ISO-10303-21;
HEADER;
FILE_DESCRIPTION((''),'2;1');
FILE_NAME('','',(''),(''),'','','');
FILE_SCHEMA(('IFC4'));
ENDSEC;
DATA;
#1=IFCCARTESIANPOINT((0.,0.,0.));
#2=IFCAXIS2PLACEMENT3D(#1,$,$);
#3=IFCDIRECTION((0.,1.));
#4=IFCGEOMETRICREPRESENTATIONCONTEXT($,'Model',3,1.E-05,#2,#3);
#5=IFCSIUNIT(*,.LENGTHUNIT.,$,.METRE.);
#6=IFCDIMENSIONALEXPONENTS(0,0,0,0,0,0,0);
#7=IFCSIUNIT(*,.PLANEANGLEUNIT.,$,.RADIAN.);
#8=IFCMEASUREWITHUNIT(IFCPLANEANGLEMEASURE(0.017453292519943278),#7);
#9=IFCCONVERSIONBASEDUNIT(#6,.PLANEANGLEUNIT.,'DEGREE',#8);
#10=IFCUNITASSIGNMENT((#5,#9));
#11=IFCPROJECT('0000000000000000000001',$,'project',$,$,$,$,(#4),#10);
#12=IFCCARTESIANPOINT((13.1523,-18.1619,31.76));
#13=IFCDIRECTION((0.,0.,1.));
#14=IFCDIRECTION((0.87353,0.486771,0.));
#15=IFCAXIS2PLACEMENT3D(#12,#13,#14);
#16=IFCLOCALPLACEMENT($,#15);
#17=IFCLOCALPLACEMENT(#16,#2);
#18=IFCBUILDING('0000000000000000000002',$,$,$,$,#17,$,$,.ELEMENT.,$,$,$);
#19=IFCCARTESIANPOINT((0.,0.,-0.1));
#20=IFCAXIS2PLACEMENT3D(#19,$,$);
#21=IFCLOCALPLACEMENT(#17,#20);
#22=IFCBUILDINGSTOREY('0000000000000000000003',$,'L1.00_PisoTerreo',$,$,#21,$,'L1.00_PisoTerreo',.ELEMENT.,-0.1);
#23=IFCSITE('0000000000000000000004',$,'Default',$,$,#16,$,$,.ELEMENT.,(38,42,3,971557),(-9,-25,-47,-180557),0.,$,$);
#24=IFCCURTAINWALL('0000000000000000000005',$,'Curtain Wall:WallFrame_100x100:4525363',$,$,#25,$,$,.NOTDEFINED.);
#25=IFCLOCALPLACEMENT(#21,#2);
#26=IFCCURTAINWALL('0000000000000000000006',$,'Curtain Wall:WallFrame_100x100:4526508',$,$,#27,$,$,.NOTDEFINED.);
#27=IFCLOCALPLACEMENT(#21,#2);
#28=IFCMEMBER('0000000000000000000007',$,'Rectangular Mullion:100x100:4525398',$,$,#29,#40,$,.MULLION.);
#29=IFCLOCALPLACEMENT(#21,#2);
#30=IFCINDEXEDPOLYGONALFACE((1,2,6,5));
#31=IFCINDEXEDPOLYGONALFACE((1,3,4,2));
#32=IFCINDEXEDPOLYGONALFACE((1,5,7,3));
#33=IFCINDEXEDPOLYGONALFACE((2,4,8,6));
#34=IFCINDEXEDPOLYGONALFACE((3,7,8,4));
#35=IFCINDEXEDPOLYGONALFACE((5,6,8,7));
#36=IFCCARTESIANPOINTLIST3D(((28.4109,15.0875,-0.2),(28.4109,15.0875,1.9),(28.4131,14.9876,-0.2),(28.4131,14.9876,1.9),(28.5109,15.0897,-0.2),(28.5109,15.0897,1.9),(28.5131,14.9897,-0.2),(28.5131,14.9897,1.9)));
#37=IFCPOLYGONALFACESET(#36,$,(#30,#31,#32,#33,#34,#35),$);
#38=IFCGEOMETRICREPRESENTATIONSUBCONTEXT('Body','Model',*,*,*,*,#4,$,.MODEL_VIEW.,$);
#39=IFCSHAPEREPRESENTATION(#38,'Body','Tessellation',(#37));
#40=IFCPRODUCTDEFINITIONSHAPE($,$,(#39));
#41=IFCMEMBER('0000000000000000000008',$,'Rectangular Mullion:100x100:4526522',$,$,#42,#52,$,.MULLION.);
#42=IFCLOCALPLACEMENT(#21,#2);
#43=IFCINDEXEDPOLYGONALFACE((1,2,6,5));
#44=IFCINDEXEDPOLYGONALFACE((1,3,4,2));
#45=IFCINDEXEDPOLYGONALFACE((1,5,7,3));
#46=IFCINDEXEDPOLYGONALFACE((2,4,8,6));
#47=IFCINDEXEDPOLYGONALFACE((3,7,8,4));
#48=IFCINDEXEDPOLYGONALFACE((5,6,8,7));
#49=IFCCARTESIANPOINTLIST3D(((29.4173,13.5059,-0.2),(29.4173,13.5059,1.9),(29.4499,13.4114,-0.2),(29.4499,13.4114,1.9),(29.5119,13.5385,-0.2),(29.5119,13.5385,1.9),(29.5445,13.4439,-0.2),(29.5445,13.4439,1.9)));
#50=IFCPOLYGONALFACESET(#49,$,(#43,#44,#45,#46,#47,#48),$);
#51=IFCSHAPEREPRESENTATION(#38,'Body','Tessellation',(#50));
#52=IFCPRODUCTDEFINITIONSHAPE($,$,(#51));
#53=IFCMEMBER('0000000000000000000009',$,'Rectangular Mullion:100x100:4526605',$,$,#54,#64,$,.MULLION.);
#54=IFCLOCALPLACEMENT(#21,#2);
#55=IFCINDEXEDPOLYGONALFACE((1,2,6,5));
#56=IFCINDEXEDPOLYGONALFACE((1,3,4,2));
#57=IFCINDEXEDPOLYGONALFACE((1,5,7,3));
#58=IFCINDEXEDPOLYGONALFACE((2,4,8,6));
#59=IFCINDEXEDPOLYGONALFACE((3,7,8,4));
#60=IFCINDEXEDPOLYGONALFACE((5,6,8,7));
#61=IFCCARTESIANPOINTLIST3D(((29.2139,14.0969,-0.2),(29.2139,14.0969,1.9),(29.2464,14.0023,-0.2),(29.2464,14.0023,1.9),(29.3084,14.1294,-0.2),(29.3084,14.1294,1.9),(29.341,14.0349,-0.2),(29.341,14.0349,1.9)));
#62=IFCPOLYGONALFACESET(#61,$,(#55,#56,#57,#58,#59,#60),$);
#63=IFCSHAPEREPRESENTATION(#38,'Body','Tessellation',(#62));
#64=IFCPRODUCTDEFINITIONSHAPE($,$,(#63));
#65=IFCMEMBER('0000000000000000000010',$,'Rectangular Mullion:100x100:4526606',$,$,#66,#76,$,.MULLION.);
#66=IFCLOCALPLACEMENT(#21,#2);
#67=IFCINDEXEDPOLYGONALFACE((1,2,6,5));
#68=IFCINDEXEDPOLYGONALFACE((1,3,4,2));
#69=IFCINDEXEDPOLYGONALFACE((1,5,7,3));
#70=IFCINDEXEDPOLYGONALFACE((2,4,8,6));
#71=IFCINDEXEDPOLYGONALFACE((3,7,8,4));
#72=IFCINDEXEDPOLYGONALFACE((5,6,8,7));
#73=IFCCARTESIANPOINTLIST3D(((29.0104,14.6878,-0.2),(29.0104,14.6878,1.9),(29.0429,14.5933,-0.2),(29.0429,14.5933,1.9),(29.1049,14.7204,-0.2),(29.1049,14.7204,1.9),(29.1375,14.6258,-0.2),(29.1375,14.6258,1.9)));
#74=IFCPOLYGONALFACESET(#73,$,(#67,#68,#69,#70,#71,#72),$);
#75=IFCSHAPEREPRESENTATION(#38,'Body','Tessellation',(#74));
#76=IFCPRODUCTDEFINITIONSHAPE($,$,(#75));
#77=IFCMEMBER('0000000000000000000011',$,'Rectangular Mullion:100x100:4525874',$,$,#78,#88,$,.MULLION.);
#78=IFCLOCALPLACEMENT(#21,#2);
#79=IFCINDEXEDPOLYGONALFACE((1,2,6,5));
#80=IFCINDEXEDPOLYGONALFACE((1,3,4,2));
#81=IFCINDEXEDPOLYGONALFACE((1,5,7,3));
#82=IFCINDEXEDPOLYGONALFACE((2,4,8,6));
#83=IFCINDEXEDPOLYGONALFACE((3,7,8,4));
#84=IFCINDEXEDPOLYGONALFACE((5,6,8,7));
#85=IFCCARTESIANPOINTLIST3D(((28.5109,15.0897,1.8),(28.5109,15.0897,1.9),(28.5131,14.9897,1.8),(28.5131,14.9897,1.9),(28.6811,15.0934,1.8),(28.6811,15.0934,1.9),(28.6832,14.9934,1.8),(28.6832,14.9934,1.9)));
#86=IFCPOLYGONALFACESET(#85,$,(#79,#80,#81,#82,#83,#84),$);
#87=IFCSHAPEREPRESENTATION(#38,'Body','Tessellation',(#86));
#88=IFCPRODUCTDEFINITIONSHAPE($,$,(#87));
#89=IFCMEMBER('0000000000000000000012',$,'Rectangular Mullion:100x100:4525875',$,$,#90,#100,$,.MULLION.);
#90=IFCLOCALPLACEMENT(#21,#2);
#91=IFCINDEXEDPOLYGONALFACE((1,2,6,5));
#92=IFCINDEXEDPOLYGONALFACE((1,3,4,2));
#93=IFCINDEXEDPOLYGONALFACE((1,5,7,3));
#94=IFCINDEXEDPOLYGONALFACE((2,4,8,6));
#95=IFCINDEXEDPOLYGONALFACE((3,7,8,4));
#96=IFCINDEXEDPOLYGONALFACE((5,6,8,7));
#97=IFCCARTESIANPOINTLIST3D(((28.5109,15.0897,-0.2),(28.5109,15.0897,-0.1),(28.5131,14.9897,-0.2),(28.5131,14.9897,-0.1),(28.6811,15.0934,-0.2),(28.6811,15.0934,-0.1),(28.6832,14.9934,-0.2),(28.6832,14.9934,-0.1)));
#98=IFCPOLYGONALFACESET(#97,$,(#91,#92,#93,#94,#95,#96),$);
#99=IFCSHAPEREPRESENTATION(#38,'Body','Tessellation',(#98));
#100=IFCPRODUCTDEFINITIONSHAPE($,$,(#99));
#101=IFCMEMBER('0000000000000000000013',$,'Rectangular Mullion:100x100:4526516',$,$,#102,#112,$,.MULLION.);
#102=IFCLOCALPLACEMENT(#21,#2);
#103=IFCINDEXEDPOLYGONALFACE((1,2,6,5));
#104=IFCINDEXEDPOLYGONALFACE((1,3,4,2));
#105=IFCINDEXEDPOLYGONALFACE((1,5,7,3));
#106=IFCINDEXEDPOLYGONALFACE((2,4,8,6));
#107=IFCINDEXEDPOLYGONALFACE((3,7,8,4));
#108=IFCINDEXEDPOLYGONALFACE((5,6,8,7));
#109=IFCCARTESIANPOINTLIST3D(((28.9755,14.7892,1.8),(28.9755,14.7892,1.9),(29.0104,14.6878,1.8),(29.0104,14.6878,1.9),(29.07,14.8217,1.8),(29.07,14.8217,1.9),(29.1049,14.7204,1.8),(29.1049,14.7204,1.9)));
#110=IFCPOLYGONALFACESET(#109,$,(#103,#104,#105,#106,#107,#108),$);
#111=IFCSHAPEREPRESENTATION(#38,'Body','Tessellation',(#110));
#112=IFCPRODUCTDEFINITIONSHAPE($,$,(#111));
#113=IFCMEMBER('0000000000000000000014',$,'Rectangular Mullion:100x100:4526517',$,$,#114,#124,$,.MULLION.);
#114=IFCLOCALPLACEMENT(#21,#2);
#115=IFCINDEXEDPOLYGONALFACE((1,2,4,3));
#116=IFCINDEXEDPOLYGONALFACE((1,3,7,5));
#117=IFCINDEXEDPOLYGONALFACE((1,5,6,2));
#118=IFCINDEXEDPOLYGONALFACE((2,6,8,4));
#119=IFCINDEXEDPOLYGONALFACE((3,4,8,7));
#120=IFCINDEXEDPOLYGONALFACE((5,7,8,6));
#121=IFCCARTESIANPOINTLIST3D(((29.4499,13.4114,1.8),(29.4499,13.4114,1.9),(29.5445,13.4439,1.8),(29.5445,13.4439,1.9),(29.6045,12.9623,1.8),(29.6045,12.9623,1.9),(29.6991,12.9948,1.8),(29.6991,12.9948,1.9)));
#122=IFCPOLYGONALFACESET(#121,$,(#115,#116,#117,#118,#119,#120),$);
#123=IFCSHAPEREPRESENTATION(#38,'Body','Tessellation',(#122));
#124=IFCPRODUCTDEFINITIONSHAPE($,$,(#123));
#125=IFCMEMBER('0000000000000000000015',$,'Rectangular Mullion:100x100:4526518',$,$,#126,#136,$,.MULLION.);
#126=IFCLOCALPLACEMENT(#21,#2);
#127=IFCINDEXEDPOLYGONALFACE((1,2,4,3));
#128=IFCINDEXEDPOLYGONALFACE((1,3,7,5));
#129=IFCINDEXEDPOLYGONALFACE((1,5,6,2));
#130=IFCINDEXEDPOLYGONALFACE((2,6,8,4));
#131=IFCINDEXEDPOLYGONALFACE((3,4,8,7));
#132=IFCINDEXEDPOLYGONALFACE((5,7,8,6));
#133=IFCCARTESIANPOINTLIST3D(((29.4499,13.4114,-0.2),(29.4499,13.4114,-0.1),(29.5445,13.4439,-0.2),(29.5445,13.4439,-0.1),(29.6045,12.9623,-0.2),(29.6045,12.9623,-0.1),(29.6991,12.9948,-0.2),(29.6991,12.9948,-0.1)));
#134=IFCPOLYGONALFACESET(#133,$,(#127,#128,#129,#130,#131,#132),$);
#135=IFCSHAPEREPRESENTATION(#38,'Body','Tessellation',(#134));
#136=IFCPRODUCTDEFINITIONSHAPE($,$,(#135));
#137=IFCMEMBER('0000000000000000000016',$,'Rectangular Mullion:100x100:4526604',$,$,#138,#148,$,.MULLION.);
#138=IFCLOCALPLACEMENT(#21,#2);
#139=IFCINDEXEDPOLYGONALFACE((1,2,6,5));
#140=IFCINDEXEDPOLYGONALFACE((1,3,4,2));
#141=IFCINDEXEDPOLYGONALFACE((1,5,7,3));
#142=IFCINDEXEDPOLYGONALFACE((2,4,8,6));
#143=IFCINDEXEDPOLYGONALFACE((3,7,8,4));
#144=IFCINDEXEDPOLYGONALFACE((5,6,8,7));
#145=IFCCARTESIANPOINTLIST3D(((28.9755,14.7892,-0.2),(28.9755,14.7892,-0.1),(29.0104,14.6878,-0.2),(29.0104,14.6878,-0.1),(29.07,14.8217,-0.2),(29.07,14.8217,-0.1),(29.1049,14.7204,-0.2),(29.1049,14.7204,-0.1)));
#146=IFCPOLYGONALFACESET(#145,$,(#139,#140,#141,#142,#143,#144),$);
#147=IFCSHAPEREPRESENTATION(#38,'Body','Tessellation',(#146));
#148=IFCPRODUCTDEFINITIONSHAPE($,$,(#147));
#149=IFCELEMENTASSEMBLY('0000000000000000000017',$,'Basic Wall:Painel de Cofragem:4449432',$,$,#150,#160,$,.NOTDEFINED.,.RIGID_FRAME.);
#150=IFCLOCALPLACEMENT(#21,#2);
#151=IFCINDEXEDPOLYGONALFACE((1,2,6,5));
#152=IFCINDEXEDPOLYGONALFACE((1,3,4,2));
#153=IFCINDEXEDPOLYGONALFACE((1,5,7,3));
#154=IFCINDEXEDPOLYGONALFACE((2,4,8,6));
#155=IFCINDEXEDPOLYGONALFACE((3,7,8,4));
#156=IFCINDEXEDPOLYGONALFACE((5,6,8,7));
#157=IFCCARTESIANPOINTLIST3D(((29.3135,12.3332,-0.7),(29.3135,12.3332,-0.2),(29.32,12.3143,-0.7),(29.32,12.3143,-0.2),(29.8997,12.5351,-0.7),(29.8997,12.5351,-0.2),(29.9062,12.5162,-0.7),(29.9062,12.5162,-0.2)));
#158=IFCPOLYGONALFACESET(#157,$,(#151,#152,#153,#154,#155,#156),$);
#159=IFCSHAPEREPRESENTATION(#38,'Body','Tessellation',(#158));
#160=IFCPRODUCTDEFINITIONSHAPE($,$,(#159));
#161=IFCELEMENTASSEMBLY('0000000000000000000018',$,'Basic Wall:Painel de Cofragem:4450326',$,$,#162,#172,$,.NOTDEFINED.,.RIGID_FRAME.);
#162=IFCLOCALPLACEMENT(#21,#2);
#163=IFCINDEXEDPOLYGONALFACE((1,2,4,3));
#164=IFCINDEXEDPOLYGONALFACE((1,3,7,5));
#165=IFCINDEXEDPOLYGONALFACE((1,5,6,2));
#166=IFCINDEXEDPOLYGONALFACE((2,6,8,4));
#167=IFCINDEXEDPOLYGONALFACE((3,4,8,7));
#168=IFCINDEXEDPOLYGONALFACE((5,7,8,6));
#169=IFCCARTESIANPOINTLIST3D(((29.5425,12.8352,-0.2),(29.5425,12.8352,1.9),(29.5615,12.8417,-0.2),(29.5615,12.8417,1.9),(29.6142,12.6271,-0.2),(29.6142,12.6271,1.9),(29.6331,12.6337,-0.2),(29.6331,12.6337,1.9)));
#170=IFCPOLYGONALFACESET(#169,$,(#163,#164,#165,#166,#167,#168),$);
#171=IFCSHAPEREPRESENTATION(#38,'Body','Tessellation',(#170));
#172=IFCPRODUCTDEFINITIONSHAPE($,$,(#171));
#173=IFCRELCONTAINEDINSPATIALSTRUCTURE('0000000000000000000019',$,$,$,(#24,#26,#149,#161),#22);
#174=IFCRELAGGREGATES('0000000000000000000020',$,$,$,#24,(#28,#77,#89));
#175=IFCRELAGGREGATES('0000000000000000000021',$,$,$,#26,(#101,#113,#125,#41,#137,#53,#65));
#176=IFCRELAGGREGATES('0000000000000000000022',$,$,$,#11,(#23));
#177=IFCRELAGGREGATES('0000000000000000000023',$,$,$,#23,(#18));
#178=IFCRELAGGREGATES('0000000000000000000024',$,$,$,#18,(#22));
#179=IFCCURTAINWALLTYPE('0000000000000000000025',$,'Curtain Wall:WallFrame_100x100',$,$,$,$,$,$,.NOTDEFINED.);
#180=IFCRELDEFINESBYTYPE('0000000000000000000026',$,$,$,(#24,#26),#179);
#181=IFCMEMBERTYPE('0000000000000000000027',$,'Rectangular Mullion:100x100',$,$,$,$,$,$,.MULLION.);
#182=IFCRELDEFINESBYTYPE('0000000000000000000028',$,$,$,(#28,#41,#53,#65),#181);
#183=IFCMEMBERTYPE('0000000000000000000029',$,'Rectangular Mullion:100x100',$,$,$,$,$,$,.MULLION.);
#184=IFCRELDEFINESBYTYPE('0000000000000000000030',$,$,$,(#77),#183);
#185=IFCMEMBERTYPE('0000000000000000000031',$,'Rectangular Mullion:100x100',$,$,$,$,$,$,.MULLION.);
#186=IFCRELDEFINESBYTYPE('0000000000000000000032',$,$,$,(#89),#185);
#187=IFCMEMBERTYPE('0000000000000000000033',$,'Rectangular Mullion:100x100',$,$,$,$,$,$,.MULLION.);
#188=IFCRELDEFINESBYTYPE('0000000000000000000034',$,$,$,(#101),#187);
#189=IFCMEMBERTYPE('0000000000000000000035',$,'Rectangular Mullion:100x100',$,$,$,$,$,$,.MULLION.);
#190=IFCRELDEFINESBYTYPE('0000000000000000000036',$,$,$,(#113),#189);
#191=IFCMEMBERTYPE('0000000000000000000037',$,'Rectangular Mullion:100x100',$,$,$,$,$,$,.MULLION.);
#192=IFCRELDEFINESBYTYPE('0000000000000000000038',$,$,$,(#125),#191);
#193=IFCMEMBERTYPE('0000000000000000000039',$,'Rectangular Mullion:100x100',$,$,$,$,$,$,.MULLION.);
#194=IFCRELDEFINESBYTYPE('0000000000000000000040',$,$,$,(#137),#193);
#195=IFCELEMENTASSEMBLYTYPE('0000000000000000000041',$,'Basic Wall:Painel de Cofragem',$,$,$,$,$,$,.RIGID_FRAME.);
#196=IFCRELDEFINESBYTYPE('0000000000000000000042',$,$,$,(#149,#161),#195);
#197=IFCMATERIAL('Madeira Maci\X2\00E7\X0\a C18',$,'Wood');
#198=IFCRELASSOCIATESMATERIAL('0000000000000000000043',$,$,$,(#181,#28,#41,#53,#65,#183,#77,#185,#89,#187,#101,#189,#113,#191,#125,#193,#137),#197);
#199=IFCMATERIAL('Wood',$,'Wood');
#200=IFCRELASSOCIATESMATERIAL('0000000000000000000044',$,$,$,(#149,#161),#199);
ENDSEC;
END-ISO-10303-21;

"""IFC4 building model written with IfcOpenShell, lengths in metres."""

from ifc_helpers import new_model, entity, si_unit, converted_unit, direction, frame, origin, place, context, subcontext, project, spatial, indexed_curve, outline, extrude, source, transform, mapped, material, type_object, type_shapes, element, aggregate, save


model = new_model("IFC4")

# Units and contexts
model_context = context("Model", 3, precision=1e-05, world=origin(), true_north=direction((0.0, 1.0)))
body_context = subcontext(model_context, "Body", "Model", "MODEL_VIEW")
ifc_project = project(units=[si_unit("LENGTHUNIT", "METRE"), converted_unit("PLANEANGLEUNIT", "DEGREE", entity("IfcPlaneAngleMeasure", 0.017453292519943278), si_unit("PLANEANGLEUNIT", "RADIAN"), dimensions=[0, 0, 0, 0, 0, 0, 0])], contexts=[model_context])

# Site, building, storey
site_placement = place(None, frame((13.1523, -18.1619, 31.76), z_axis=(0.0, 0.0, 1.0), x_axis=(0.87353, 0.486771, 0.0)))
site = spatial("IfcSite", under=ifc_project, at=site_placement, Name="Default", CompositionType="ELEMENT", RefLatitude=(38, 42, 3, 971557), RefLongitude=(-9, -25, -47, -180557), RefElevation=0.0)
building_placement = place(site_placement, origin())
building = spatial("IfcBuilding", under=site, at=building_placement, CompositionType="ELEMENT")
storey_placement = place(building_placement, frame((0.0, 0.0, -0.1)))
storey = spatial("IfcBuildingStorey", under=building, at=storey_placement, Name="L1.00_PisoTerreo", LongName="L1.00_PisoTerreo", CompositionType="ELEMENT", Elevation=-0.1)

# Curtain walls
curtain_wall_type = type_object("IfcCurtainWallType", Name="Curtain Wall:WallFrame_100x100", PredefinedType="NOTDEFINED")
curtain_wall_1_placement = place(storey_placement, frame((0.0, 0.0, 0.1)))
curtain_wall_1 = element("IfcCurtainWall", 1, at=curtain_wall_1_placement, inside=storey, type_object=curtain_wall_type, Name="Curtain Wall:WallFrame_100x100:4525363", PredefinedType="NOTDEFINED")
ifc_material_1 = material(Name="Madeira Maciça C18", Category="Wood")
curtain_wall_2_placement = place(storey_placement, frame((0.0, 0.0, 0.1)))
curtain_wall_2 = element("IfcCurtainWall", 2, at=curtain_wall_2_placement, inside=storey, type_object=curtain_wall_type, Name="Curtain Wall:WallFrame_100x100:4526508", PredefinedType="NOTDEFINED")

# Members
member_type_1 = type_object("IfcMemberType", Name="Rectangular Mullion:100x100", PredefinedType="MULLION", material=ifc_material_1)
shared_shape_1 = source(origin(), body_context, "Body", "SweptSolid", [
    extrude(outline(indexed_curve([(-0.05, -0.05), (0.05, -0.05), (0.05, 0.05), (-0.05, 0.05), (-0.05, -0.05)], self_intersect=False)), frame((0.0, 0.0, -2.1), z_axis=(0.0, 0.0, 1.0), x_axis=(-1.0, 0.0, 0.0)), (0.0, 0.0, 1.0), 2.1),
])
type_shapes(member_type_1, [shared_shape_1])
member_1_placement = place(curtain_wall_1_placement, frame((28.462, 15.0386, -0.3), z_axis=(0.0, 0.0, -1.0), x_axis=(0.999767, 0.021581, 0.0)))
member_1 = element("IfcMember", 3, at=member_1_placement, type_object=member_type_1, material=ifc_material_1, Name="Rectangular Mullion:100x100:4525398", PredefinedType="MULLION", context=body_context, shape_type="MappedRepresentation", body=[
    mapped(shared_shape_1, transform((0.0, 0.0, 0.0), scale=1.0)),
])
member_2_placement = place(curtain_wall_2_placement, frame((29.4809, 13.4749, -0.3), z_axis=(0.0, 0.0, -1.0), x_axis=(-0.325568, 0.945519, 0.0)))
member_2 = element("IfcMember", 4, at=member_2_placement, type_object=member_type_1, material=ifc_material_1, Name="Rectangular Mullion:100x100:4526522", PredefinedType="MULLION", context=body_context, shape_type="MappedRepresentation", body=[
    mapped(shared_shape_1, transform((0.0, 0.0, 0.0), scale=1.0)),
])
member_3_placement = place(curtain_wall_2_placement, frame((29.2774, 14.0659, -0.3), z_axis=(0.0, 0.0, -1.0), x_axis=(-0.325568, 0.945519, 0.0)))
member_3 = element("IfcMember", 5, at=member_3_placement, type_object=member_type_1, material=ifc_material_1, Name="Rectangular Mullion:100x100:4526605", PredefinedType="MULLION", context=body_context, shape_type="MappedRepresentation", body=[
    mapped(shared_shape_1, transform((0.0, 0.0, 0.0), scale=1.0)),
])
member_4_placement = place(curtain_wall_2_placement, frame((29.0739, 14.6568, -0.3), z_axis=(0.0, 0.0, -1.0), x_axis=(-0.325568, 0.945519, 0.0)))
member_4 = element("IfcMember", 6, at=member_4_placement, type_object=member_type_1, material=ifc_material_1, Name="Rectangular Mullion:100x100:4526606", PredefinedType="MULLION", context=body_context, shape_type="MappedRepresentation", body=[
    mapped(shared_shape_1, transform((0.0, 0.0, 0.0), scale=1.0)),
])
member_type_2 = type_object("IfcMemberType", Name="Rectangular Mullion:100x100", PredefinedType="MULLION", material=ifc_material_1)
shared_shape_2 = source(origin(), body_context, "Body", "SweptSolid", [
    extrude(outline(indexed_curve([(-0.05, -0.05), (0.05, -0.05), (0.05, 0.05), (-0.05, 0.05), (-0.05, -0.05)], self_intersect=False)), frame((-0.05, 0.0, -0.1702), z_axis=(0.0, 0.0, 1.0), x_axis=(-1.0, 0.0, 0.0)), (0.0, 0.0, 1.0), 0.1702),
])
type_shapes(member_type_2, [shared_shape_2])
member_5_placement = place(curtain_wall_1_placement, frame((28.6821, 15.0434, 1.8), z_axis=(0.999767, 0.021581, 0.0), x_axis=(0.0, 0.0, 1.0)))
member_5 = element("IfcMember", 7, at=member_5_placement, type_object=member_type_2, material=ifc_material_1, Name="Rectangular Mullion:100x100:4525874", PredefinedType="MULLION", context=body_context, shape_type="MappedRepresentation", body=[
    mapped(shared_shape_2, transform((0.0, 0.0, 0.0), scale=1.0)),
])
member_type_3 = type_object("IfcMemberType", Name="Rectangular Mullion:100x100", PredefinedType="MULLION", material=ifc_material_1)
shared_shape_3 = source(origin(), body_context, "Body", "SweptSolid", [
    extrude(outline(indexed_curve([(-0.05, -0.05), (0.05, -0.05), (0.05, 0.05), (-0.05, 0.05), (-0.05, -0.05)], self_intersect=False)), frame((-0.05, 0.0, -0.1702), z_axis=(0.0, 0.0, 1.0), x_axis=(0.0, -1.0, 0.0)), (0.0, 0.0, 1.0), 0.1702),
])
type_shapes(member_type_3, [shared_shape_3])
member_6_placement = place(curtain_wall_1_placement, frame((28.512, 15.0397, -0.3), z_axis=(-0.999767, -0.021581, 0.0), x_axis=(0.0, 0.0, -1.0)))
member_6 = element("IfcMember", 8, at=member_6_placement, type_object=member_type_3, material=ifc_material_1, Name="Rectangular Mullion:100x100:4525875", PredefinedType="MULLION", context=body_context, shape_type="MappedRepresentation", body=[
    mapped(shared_shape_3, transform((0.0, 0.0, 0.0), scale=1.0)),
])
aggregate(curtain_wall_1, [member_1, member_5, member_6])
member_type_4 = type_object("IfcMemberType", Name="Rectangular Mullion:100x100", PredefinedType="MULLION", material=ifc_material_1)
shared_shape_4 = source(origin(), body_context, "Body", "SweptSolid", [
    extrude(outline(indexed_curve([(-0.05, -0.05), (0.05, -0.05), (0.05, 0.05), (-0.05, 0.05), (-0.05, -0.05)], self_intersect=False)), frame((-0.05, 0.0, -0.1072), z_axis=(0.0, 0.0, 1.0), x_axis=(-1.0, 0.0, 0.0)), (0.0, 0.0, 1.0), 0.1072),
])
type_shapes(member_type_4, [shared_shape_4])
member_7_placement = place(curtain_wall_2_placement, frame((29.0228, 14.8054, 1.8), z_axis=(-0.325568, 0.945519, 0.0), x_axis=(0.0, 0.0, 1.0)))
member_7 = element("IfcMember", 9, at=member_7_placement, type_object=member_type_4, material=ifc_material_1, Name="Rectangular Mullion:100x100:4526516", PredefinedType="MULLION", context=body_context, shape_type="MappedRepresentation", body=[
    mapped(shared_shape_4, transform((0.0, 0.0, 0.0), scale=1.0)),
])
member_type_5 = type_object("IfcMemberType", Name="Rectangular Mullion:100x100", PredefinedType="MULLION", material=ifc_material_1)
shared_shape_5 = source(origin(), body_context, "Body", "SweptSolid", [
    extrude(outline(indexed_curve([(-0.05, -0.05), (0.05, -0.05), (0.05, 0.05), (-0.05, 0.05), (-0.05, -0.05)], self_intersect=False)), frame((-0.05, 0.0, -0.475), z_axis=(0.0, 0.0, 1.0), x_axis=(-1.0, 0.0, 0.0)), (0.0, 0.0, 1.0), 0.475),
])
type_shapes(member_type_5, [shared_shape_5])
member_8_placement = place(curtain_wall_2_placement, frame((29.4972, 13.4277, 1.8), z_axis=(-0.325568, 0.945519, 0.0), x_axis=(0.0, 0.0, 1.0)))
member_8 = element("IfcMember", 10, at=member_8_placement, type_object=member_type_5, material=ifc_material_1, Name="Rectangular Mullion:100x100:4526517", PredefinedType="MULLION", context=body_context, shape_type="MappedRepresentation", body=[
    mapped(shared_shape_5, transform((0.0, 0.0, 0.0), scale=1.0)),
])
member_type_6 = type_object("IfcMemberType", Name="Rectangular Mullion:100x100", PredefinedType="MULLION", material=ifc_material_1)
shared_shape_6 = source(origin(), body_context, "Body", "SweptSolid", [
    extrude(outline(indexed_curve([(-0.05, -0.05), (0.05, -0.05), (0.05, 0.05), (-0.05, 0.05), (-0.05, -0.05)], self_intersect=False)), frame((-0.05, 0.0, -0.475), z_axis=(0.0, 0.0, 1.0), x_axis=(0.0, -1.0, 0.0)), (0.0, 0.0, 1.0), 0.475),
])
type_shapes(member_type_6, [shared_shape_6])
member_9_placement = place(curtain_wall_2_placement, frame((29.6518, 12.9785, -0.3), z_axis=(0.325568, -0.945519, 0.0), x_axis=(0.0, 0.0, -1.0)))
member_9 = element("IfcMember", 11, at=member_9_placement, type_object=member_type_6, material=ifc_material_1, Name="Rectangular Mullion:100x100:4526518", PredefinedType="MULLION", context=body_context, shape_type="MappedRepresentation", body=[
    mapped(shared_shape_6, transform((0.0, 0.0, 0.0), scale=1.0)),
])
member_type_7 = type_object("IfcMemberType", Name="Rectangular Mullion:100x100", PredefinedType="MULLION", material=ifc_material_1)
shared_shape_7 = source(origin(), body_context, "Body", "SweptSolid", [
    extrude(outline(indexed_curve([(-0.05, -0.05), (0.05, -0.05), (0.05, 0.05), (-0.05, 0.05), (-0.05, -0.05)], self_intersect=False)), frame((-0.05, 0.0, -0.1072), z_axis=(0.0, 0.0, 1.0), x_axis=(0.0, -1.0, 0.0)), (0.0, 0.0, 1.0), 0.1072),
])
type_shapes(member_type_7, [shared_shape_7])
member_10_placement = place(curtain_wall_2_placement, frame((29.0577, 14.7041, -0.3), z_axis=(0.325568, -0.945519, 0.0), x_axis=(0.0, 0.0, -1.0)))
member_10 = element("IfcMember", 12, at=member_10_placement, type_object=member_type_7, material=ifc_material_1, Name="Rectangular Mullion:100x100:4526604", PredefinedType="MULLION", context=body_context, shape_type="MappedRepresentation", body=[
    mapped(shared_shape_7, transform((0.0, 0.0, 0.0), scale=1.0)),
])
aggregate(curtain_wall_2, [member_7, member_8, member_9, member_2, member_10, member_3, member_4])

# Element assemblies
ifc_material_2 = material(Name="Wood", Category="Wood")
element_assembly_type = type_object("IfcElementAssemblyType", Name="Basic Wall:Painel de Cofragem", PredefinedType="RIGID_FRAME")
assembly_1_placement = place(storey_placement, frame((29.3167, 12.3238, -0.7), z_axis=(0.0, 0.0, 1.0), x_axis=(0.945519, 0.325568, 0.0)))
element("IfcElementAssembly", 13, at=assembly_1_placement, inside=storey, type_object=element_assembly_type, material=ifc_material_2, Name="Basic Wall:Painel de Cofragem:4449432", AssemblyPlace="NOTDEFINED", PredefinedType="RIGID_FRAME", context=body_context, shape_type="SweptSolid", body=[
    extrude(outline(indexed_curve([(0.62, 0.01), (0.0, 0.01), (0.0, -0.01), (0.62, -0.01), (0.62, 0.01)], self_intersect=False)), origin(), (0.0, 0.0, 1.0), 0.5),
])
assembly_2_placement = place(storey_placement, frame((29.552, 12.8384, -0.2), z_axis=(0.0, 0.0, 1.0), x_axis=(0.325568, -0.945519, 0.0)))
element("IfcElementAssembly", 14, at=assembly_2_placement, inside=storey, type_object=element_assembly_type, material=ifc_material_2, Name="Basic Wall:Painel de Cofragem:4450326", AssemblyPlace="NOTDEFINED", PredefinedType="RIGID_FRAME", context=body_context, shape_type="SweptSolid", body=[
    extrude(outline(indexed_curve([(0.22, 0.01), (0.0, 0.01), (0.0, -0.01), (0.22, -0.01), (0.22, 0.01)], self_intersect=False)), origin(), (0.0, 0.0, 1.0), 2.1),
])

save(model, "model.ifc")
